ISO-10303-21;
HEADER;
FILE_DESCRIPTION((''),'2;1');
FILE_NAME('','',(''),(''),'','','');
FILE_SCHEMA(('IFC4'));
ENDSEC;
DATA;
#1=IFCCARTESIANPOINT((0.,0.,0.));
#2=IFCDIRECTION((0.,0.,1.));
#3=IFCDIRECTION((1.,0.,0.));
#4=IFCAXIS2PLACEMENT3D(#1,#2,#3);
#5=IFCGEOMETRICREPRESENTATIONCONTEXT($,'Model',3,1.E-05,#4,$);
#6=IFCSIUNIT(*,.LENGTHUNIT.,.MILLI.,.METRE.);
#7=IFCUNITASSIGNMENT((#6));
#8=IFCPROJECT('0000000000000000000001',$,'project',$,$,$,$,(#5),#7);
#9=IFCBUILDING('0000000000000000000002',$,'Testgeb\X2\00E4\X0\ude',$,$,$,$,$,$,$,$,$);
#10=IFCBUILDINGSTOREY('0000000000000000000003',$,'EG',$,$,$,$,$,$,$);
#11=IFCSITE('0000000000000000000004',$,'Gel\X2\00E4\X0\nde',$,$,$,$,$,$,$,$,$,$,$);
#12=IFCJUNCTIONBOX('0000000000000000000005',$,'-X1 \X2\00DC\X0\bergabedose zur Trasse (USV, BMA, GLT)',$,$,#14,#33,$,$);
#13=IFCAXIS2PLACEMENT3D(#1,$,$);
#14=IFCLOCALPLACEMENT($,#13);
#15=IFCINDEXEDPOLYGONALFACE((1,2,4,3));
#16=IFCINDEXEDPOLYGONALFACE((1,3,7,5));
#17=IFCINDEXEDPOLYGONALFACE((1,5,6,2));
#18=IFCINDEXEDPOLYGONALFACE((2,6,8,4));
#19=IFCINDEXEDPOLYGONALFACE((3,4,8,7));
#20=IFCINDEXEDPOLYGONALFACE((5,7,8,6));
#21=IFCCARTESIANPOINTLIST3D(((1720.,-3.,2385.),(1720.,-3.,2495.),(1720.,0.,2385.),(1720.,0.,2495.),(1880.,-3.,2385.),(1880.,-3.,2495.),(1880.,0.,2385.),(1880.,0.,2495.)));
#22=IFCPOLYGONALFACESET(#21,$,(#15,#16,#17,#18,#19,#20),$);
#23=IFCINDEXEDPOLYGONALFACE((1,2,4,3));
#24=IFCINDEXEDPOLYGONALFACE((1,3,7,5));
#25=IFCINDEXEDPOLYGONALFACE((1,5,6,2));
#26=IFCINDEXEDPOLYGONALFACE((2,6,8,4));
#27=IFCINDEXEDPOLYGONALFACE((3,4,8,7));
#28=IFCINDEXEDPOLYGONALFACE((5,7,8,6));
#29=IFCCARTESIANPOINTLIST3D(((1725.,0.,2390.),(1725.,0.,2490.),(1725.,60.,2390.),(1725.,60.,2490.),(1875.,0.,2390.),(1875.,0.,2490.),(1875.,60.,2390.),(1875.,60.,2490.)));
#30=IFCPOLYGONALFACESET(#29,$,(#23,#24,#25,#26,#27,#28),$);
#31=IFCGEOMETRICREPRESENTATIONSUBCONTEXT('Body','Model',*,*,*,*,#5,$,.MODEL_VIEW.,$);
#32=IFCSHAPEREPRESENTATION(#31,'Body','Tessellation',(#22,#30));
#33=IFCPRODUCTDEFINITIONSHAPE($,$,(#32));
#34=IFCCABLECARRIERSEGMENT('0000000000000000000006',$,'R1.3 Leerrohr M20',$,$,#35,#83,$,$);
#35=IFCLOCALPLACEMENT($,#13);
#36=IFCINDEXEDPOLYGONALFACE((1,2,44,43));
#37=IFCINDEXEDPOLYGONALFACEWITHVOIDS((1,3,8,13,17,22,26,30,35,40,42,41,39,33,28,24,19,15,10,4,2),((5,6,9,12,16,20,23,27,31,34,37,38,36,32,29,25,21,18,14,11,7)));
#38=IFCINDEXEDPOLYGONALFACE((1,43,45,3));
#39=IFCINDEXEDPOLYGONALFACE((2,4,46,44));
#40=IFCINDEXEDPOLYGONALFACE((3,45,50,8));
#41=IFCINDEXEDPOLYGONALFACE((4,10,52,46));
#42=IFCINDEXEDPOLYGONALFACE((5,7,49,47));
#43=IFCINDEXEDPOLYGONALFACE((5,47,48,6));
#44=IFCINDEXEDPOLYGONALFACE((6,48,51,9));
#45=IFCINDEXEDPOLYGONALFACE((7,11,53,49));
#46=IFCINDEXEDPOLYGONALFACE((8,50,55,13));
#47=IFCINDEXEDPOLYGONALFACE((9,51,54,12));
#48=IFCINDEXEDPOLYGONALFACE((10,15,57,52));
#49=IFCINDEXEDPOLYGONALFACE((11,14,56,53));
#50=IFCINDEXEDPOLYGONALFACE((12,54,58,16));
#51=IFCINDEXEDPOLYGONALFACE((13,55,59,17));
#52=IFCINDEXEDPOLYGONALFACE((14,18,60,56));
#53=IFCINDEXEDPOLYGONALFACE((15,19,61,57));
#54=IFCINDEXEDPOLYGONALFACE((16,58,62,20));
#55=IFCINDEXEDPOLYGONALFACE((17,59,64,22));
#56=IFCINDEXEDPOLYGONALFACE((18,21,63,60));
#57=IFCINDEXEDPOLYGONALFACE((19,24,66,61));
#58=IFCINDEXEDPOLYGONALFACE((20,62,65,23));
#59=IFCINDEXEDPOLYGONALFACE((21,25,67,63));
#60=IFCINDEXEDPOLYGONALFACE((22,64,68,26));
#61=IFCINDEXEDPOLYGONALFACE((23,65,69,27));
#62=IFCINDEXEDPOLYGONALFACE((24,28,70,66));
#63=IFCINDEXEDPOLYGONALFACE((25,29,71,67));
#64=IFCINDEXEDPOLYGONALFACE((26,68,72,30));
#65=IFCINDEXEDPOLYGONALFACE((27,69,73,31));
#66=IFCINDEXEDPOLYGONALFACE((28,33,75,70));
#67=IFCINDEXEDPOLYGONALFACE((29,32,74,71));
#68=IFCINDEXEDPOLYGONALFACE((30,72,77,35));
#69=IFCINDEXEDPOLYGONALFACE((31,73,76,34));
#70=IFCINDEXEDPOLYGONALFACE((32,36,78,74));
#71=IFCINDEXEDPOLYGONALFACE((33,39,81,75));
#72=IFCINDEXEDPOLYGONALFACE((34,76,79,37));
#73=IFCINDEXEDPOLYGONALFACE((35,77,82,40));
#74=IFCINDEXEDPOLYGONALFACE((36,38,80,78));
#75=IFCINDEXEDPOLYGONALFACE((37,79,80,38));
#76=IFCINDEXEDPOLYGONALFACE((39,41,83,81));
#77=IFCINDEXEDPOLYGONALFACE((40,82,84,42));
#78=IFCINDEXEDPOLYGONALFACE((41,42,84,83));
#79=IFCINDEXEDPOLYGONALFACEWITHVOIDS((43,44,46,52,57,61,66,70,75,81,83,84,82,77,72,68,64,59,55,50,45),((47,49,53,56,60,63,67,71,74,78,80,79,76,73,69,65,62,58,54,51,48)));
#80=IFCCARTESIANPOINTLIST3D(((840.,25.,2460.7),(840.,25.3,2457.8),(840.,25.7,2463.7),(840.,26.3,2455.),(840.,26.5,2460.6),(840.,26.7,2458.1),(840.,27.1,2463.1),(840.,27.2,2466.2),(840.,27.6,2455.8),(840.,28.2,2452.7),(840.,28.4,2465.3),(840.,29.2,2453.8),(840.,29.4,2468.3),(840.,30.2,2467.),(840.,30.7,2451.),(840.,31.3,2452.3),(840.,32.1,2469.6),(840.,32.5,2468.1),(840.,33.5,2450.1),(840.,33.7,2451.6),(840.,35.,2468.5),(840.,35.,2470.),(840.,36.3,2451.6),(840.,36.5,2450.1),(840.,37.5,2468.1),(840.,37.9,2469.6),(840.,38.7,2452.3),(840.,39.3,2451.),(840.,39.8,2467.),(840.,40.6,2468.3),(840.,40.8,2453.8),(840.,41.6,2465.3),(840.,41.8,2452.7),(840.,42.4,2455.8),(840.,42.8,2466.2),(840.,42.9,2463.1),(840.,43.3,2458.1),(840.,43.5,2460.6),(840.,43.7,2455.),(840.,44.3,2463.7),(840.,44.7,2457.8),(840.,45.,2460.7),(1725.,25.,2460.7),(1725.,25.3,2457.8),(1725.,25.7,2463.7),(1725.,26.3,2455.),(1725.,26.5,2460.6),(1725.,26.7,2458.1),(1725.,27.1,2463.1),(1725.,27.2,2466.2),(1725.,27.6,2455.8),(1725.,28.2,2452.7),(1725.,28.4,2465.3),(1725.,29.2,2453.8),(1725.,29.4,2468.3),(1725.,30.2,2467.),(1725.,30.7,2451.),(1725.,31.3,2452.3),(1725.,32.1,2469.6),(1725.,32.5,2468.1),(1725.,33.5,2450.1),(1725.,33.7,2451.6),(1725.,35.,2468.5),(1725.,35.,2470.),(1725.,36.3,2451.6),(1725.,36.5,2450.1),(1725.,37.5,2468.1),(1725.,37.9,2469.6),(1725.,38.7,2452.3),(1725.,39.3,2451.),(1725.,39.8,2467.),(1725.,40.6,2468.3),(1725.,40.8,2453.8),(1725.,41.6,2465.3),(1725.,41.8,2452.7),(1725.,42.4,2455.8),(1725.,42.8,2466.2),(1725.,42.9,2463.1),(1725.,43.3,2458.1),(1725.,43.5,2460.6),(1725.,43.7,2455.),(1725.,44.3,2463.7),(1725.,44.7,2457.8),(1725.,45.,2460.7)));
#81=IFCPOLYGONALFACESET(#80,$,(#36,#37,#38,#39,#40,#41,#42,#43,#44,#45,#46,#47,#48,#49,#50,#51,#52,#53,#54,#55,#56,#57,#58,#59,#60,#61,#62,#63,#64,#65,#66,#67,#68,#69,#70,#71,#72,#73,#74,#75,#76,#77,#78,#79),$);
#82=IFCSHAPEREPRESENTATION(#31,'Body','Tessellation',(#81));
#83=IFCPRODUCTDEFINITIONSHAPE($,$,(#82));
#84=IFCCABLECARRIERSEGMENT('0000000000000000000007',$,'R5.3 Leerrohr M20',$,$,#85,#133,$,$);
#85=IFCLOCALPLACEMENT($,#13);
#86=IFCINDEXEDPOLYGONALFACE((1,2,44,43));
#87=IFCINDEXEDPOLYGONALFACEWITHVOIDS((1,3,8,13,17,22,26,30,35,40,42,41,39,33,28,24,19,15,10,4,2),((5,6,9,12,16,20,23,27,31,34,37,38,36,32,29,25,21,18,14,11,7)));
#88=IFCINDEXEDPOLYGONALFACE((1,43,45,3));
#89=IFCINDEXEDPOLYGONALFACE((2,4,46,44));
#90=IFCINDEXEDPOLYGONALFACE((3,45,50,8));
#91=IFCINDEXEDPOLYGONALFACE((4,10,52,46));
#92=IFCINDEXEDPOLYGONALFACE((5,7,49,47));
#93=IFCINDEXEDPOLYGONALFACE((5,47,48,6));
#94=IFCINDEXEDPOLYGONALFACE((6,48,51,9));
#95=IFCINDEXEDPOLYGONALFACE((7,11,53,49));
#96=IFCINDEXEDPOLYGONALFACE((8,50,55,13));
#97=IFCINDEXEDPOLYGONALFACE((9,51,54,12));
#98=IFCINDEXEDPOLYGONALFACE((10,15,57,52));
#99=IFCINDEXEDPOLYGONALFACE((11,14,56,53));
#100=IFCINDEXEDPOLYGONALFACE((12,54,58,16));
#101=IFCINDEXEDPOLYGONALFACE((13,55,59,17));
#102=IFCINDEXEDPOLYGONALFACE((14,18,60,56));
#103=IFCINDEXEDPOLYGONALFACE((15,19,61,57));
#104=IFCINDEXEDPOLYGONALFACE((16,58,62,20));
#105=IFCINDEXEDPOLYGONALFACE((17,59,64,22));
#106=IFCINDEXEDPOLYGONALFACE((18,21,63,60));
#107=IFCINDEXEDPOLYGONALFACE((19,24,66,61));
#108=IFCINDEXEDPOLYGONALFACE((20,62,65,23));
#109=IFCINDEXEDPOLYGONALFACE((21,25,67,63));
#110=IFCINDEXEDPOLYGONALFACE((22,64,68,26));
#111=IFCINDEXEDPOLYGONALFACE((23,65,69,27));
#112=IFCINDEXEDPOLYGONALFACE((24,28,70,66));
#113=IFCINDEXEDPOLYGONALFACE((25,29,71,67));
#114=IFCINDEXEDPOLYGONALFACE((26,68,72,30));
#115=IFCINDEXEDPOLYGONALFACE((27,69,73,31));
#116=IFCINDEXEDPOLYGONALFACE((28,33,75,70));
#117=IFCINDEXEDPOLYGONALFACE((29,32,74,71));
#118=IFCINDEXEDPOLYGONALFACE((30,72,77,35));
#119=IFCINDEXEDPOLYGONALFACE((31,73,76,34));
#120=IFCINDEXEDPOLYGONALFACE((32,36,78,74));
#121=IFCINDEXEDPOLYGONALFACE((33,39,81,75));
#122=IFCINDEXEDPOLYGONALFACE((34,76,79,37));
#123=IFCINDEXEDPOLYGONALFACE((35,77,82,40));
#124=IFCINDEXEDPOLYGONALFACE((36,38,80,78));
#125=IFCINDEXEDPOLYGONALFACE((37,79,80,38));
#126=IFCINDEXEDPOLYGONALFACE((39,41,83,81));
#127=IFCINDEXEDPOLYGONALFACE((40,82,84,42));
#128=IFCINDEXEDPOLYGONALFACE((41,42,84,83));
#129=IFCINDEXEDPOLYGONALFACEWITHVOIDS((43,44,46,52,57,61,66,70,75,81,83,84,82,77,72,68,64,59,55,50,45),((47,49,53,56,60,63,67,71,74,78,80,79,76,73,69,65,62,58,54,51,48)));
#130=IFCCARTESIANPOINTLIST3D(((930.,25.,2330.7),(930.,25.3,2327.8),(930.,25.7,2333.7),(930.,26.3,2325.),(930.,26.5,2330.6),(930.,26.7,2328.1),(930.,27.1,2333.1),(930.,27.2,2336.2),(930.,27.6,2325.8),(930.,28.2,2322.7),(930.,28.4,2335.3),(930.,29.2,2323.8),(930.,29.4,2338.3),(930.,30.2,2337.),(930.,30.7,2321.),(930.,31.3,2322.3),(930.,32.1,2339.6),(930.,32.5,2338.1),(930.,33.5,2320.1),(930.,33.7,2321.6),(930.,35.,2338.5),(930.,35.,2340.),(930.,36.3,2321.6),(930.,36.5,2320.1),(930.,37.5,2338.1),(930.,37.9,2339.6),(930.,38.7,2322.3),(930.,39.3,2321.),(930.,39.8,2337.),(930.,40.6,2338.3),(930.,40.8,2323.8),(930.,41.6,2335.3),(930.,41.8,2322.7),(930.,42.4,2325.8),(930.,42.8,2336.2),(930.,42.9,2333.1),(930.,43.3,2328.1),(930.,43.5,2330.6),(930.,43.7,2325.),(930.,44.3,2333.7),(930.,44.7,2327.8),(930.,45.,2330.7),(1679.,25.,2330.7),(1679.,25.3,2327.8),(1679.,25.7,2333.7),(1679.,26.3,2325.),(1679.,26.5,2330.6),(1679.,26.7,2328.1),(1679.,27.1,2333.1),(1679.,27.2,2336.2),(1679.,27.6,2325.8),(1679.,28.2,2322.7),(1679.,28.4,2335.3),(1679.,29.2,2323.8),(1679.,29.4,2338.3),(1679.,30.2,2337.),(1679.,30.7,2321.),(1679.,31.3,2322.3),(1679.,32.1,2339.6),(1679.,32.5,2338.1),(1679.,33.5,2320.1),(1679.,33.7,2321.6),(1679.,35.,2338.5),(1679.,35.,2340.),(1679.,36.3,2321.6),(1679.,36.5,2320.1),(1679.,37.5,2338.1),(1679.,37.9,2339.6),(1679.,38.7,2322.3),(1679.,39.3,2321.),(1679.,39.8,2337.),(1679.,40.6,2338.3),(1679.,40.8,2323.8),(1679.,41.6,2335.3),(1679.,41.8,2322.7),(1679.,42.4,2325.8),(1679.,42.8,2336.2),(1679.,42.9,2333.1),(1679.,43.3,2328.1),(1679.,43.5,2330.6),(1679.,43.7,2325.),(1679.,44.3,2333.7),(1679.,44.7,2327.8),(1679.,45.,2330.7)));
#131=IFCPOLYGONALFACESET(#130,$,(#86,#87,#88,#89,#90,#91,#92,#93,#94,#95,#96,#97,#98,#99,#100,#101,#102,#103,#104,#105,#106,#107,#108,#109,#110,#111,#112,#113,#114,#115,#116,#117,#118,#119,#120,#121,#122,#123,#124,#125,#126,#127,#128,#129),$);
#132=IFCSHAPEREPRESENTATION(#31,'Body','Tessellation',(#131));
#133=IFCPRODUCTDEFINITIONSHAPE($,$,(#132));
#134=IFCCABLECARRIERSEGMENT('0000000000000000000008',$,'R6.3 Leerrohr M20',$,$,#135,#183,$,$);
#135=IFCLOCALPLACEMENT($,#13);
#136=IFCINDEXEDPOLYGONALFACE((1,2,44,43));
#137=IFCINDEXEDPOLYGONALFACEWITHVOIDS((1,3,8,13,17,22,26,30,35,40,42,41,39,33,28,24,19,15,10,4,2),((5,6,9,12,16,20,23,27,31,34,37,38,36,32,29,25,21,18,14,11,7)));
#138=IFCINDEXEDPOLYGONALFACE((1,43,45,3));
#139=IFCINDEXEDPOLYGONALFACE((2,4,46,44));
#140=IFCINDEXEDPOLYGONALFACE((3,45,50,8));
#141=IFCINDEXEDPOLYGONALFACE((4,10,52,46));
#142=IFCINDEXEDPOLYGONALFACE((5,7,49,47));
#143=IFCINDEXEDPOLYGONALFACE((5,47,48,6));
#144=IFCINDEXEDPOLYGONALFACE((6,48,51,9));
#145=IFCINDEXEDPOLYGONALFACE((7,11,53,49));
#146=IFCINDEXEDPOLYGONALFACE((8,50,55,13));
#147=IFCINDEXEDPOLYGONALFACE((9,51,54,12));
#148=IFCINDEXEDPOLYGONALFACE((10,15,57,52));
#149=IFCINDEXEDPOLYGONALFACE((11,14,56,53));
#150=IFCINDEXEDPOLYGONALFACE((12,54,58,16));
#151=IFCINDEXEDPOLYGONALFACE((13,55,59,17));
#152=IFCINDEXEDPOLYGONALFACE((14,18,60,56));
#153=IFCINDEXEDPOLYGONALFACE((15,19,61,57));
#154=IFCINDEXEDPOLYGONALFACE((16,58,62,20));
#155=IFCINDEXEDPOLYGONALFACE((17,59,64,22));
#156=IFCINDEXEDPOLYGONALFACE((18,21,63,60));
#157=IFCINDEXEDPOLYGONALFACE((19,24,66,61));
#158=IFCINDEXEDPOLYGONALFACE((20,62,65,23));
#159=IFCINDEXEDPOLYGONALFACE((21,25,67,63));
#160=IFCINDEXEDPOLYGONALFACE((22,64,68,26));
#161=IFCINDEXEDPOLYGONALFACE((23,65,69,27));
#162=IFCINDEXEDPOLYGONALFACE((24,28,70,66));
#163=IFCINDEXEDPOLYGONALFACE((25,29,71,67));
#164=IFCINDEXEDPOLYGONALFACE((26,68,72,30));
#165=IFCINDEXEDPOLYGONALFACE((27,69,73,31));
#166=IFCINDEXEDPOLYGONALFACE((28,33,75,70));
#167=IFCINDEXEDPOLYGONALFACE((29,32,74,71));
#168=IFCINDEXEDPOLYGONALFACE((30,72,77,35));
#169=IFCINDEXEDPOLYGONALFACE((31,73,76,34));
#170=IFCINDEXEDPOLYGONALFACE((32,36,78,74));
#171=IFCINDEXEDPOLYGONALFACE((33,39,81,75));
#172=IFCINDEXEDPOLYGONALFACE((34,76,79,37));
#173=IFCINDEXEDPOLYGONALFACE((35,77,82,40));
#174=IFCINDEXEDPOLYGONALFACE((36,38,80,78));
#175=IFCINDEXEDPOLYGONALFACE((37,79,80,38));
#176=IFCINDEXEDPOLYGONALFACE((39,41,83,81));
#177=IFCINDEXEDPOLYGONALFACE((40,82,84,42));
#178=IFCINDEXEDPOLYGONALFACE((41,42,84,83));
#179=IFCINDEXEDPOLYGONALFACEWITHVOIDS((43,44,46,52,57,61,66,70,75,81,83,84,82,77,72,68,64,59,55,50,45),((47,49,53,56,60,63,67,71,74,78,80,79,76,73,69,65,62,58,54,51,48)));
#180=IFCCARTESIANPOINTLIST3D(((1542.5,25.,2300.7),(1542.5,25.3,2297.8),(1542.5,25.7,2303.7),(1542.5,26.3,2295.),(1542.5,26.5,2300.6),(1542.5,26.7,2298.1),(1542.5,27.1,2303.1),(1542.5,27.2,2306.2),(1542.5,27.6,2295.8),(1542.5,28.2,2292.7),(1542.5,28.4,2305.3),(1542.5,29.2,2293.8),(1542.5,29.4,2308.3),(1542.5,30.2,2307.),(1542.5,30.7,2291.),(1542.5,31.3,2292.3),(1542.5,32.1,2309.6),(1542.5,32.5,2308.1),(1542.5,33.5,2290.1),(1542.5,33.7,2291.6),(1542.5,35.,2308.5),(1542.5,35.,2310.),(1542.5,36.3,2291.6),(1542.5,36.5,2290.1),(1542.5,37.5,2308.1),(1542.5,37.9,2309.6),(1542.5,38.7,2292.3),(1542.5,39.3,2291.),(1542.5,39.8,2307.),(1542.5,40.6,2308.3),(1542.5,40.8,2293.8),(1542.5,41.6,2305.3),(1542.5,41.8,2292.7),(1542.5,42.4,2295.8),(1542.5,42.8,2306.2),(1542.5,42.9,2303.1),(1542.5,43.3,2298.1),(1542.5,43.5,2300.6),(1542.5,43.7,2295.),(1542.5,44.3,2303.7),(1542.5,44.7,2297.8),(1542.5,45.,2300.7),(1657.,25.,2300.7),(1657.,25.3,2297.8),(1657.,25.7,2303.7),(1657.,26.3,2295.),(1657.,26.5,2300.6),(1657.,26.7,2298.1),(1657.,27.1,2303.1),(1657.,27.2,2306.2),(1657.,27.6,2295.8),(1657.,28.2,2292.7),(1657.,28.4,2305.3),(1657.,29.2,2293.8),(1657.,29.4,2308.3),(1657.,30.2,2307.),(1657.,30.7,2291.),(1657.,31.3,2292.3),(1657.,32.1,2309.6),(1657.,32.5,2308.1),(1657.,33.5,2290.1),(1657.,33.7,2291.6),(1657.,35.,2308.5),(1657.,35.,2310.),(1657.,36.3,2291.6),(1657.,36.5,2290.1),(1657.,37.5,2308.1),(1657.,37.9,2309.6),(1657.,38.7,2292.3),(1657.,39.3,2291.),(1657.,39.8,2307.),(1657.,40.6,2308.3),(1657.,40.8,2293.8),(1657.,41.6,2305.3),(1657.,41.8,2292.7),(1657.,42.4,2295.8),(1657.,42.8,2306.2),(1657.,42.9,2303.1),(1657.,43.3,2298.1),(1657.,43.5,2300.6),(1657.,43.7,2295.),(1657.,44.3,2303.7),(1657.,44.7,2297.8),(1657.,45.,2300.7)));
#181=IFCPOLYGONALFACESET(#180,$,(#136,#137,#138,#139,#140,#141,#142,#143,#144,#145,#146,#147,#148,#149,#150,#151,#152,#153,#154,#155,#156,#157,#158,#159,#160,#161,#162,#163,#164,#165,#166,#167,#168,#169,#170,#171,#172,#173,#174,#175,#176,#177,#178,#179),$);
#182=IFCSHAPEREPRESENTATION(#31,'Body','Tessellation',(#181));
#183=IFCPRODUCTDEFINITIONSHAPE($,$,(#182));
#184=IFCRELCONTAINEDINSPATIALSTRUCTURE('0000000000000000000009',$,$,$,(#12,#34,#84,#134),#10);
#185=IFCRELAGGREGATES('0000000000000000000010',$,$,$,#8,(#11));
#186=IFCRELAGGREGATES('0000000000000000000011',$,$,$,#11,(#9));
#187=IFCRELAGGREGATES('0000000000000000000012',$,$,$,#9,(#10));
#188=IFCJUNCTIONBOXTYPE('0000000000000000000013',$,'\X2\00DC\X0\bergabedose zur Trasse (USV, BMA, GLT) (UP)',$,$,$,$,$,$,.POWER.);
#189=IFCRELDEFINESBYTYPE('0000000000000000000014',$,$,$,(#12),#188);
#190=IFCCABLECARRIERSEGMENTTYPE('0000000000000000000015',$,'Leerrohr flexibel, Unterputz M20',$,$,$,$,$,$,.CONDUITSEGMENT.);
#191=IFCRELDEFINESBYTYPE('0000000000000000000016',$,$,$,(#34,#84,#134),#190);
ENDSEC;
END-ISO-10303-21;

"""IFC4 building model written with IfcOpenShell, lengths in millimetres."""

from ifc_helpers import new_model, si_unit, frame, frame_2d, origin_with_axes, place, context, subcontext, project, spatial, rectangle, hollow_circle, extrude, type_object, element, save


model = new_model("IFC4")

# Units and contexts
model_context = context("Model", 3, precision=1e-05, world=origin_with_axes())
body_context = subcontext(model_context, "Body", "Model", "MODEL_VIEW")
ifc_project = project(units=[si_unit("LENGTHUNIT", "METRE", prefix="MILLI")], contexts=[model_context])

# Site, building, storey
site = spatial("IfcSite", under=ifc_project, Name="Gelände")
building = spatial("IfcBuilding", under=site, Name="Testgebäude")
storey = spatial("IfcBuildingStorey", under=building, Name="EG")

# Junction box
junction_box_type = type_object("IfcJunctionBoxType", Name="Übergabedose zur Trasse (USV, BMA, GLT) (UP)", PredefinedType="POWER")
junction_box_placement = place(None, frame((1720.0, -3.0, 2385.0), z_axis=(0.0, 0.0, 1.0), x_axis=(1.0, 0.0, 0.0)))
element("IfcJunctionBox", 1, at=junction_box_placement, inside=storey, type_object=junction_box_type, Name="-X1 Übergabedose zur Trasse (USV, BMA, GLT)", context=body_context, shape_type="SweptSolid", body=[
    extrude(rectangle(XDim=160.0, YDim=3.0, at=frame_2d((80.0, 1.5))), None, (0.0, 0.0, 1.0), 110.0),
    extrude(rectangle(XDim=150.0, YDim=60.0, at=frame_2d((75.0, 30.0))), frame((5.0, 3.0, 5.0), z_axis=(0.0, 0.0, 1.0), x_axis=(1.0, 0.0, 0.0)), (0.0, 0.0, 1.0), 100.0),
])

# Cable carrier segments
cable_carrier_segment_type_1 = type_object("IfcCableCarrierSegmentType", Name="Leerrohr flexibel, Unterputz M20", PredefinedType="CONDUITSEGMENT")
cable_carrier_segment_1_placement = place(None, frame((840.0, 35.0, 2460.0), z_axis=(1.0, 0.0, 0.0), x_axis=(0.0, 0.0, 1.0)))
element("IfcCableCarrierSegment", 2, at=cable_carrier_segment_1_placement, inside=storey, type_object=cable_carrier_segment_type_1, Name="R1.3 Leerrohr M20", context=body_context, shape_type="SweptSolid", body=[
    extrude(hollow_circle(Radius=10.0, WallThickness=1.5), None, (0.0, 0.0, 1.0), 885.0),
])
cable_carrier_segment_2_placement = place(None, frame((930.0, 35.0, 2330.0), z_axis=(1.0, 0.0, 0.0), x_axis=(0.0, 0.0, 1.0)))
element("IfcCableCarrierSegment", 3, at=cable_carrier_segment_2_placement, inside=storey, type_object=cable_carrier_segment_type_1, Name="R5.3 Leerrohr M20", context=body_context, shape_type="SweptSolid", body=[
    extrude(hollow_circle(Radius=10.0, WallThickness=1.5), None, (0.0, 0.0, 1.0), 749.0),
])
cable_carrier_segment_3_placement = place(None, frame((1542.5, 35.0, 2300.0), z_axis=(1.0, 0.0, 0.0), x_axis=(0.0, 0.0, 1.0)))
element("IfcCableCarrierSegment", 4, at=cable_carrier_segment_3_placement, inside=storey, type_object=cable_carrier_segment_type_1, Name="R6.3 Leerrohr M20", context=body_context, shape_type="SweptSolid", body=[
    extrude(hollow_circle(Radius=10.0, WallThickness=1.5), None, (0.0, 0.0, 1.0), 114.5),
])

save(model, "model.ifc")
